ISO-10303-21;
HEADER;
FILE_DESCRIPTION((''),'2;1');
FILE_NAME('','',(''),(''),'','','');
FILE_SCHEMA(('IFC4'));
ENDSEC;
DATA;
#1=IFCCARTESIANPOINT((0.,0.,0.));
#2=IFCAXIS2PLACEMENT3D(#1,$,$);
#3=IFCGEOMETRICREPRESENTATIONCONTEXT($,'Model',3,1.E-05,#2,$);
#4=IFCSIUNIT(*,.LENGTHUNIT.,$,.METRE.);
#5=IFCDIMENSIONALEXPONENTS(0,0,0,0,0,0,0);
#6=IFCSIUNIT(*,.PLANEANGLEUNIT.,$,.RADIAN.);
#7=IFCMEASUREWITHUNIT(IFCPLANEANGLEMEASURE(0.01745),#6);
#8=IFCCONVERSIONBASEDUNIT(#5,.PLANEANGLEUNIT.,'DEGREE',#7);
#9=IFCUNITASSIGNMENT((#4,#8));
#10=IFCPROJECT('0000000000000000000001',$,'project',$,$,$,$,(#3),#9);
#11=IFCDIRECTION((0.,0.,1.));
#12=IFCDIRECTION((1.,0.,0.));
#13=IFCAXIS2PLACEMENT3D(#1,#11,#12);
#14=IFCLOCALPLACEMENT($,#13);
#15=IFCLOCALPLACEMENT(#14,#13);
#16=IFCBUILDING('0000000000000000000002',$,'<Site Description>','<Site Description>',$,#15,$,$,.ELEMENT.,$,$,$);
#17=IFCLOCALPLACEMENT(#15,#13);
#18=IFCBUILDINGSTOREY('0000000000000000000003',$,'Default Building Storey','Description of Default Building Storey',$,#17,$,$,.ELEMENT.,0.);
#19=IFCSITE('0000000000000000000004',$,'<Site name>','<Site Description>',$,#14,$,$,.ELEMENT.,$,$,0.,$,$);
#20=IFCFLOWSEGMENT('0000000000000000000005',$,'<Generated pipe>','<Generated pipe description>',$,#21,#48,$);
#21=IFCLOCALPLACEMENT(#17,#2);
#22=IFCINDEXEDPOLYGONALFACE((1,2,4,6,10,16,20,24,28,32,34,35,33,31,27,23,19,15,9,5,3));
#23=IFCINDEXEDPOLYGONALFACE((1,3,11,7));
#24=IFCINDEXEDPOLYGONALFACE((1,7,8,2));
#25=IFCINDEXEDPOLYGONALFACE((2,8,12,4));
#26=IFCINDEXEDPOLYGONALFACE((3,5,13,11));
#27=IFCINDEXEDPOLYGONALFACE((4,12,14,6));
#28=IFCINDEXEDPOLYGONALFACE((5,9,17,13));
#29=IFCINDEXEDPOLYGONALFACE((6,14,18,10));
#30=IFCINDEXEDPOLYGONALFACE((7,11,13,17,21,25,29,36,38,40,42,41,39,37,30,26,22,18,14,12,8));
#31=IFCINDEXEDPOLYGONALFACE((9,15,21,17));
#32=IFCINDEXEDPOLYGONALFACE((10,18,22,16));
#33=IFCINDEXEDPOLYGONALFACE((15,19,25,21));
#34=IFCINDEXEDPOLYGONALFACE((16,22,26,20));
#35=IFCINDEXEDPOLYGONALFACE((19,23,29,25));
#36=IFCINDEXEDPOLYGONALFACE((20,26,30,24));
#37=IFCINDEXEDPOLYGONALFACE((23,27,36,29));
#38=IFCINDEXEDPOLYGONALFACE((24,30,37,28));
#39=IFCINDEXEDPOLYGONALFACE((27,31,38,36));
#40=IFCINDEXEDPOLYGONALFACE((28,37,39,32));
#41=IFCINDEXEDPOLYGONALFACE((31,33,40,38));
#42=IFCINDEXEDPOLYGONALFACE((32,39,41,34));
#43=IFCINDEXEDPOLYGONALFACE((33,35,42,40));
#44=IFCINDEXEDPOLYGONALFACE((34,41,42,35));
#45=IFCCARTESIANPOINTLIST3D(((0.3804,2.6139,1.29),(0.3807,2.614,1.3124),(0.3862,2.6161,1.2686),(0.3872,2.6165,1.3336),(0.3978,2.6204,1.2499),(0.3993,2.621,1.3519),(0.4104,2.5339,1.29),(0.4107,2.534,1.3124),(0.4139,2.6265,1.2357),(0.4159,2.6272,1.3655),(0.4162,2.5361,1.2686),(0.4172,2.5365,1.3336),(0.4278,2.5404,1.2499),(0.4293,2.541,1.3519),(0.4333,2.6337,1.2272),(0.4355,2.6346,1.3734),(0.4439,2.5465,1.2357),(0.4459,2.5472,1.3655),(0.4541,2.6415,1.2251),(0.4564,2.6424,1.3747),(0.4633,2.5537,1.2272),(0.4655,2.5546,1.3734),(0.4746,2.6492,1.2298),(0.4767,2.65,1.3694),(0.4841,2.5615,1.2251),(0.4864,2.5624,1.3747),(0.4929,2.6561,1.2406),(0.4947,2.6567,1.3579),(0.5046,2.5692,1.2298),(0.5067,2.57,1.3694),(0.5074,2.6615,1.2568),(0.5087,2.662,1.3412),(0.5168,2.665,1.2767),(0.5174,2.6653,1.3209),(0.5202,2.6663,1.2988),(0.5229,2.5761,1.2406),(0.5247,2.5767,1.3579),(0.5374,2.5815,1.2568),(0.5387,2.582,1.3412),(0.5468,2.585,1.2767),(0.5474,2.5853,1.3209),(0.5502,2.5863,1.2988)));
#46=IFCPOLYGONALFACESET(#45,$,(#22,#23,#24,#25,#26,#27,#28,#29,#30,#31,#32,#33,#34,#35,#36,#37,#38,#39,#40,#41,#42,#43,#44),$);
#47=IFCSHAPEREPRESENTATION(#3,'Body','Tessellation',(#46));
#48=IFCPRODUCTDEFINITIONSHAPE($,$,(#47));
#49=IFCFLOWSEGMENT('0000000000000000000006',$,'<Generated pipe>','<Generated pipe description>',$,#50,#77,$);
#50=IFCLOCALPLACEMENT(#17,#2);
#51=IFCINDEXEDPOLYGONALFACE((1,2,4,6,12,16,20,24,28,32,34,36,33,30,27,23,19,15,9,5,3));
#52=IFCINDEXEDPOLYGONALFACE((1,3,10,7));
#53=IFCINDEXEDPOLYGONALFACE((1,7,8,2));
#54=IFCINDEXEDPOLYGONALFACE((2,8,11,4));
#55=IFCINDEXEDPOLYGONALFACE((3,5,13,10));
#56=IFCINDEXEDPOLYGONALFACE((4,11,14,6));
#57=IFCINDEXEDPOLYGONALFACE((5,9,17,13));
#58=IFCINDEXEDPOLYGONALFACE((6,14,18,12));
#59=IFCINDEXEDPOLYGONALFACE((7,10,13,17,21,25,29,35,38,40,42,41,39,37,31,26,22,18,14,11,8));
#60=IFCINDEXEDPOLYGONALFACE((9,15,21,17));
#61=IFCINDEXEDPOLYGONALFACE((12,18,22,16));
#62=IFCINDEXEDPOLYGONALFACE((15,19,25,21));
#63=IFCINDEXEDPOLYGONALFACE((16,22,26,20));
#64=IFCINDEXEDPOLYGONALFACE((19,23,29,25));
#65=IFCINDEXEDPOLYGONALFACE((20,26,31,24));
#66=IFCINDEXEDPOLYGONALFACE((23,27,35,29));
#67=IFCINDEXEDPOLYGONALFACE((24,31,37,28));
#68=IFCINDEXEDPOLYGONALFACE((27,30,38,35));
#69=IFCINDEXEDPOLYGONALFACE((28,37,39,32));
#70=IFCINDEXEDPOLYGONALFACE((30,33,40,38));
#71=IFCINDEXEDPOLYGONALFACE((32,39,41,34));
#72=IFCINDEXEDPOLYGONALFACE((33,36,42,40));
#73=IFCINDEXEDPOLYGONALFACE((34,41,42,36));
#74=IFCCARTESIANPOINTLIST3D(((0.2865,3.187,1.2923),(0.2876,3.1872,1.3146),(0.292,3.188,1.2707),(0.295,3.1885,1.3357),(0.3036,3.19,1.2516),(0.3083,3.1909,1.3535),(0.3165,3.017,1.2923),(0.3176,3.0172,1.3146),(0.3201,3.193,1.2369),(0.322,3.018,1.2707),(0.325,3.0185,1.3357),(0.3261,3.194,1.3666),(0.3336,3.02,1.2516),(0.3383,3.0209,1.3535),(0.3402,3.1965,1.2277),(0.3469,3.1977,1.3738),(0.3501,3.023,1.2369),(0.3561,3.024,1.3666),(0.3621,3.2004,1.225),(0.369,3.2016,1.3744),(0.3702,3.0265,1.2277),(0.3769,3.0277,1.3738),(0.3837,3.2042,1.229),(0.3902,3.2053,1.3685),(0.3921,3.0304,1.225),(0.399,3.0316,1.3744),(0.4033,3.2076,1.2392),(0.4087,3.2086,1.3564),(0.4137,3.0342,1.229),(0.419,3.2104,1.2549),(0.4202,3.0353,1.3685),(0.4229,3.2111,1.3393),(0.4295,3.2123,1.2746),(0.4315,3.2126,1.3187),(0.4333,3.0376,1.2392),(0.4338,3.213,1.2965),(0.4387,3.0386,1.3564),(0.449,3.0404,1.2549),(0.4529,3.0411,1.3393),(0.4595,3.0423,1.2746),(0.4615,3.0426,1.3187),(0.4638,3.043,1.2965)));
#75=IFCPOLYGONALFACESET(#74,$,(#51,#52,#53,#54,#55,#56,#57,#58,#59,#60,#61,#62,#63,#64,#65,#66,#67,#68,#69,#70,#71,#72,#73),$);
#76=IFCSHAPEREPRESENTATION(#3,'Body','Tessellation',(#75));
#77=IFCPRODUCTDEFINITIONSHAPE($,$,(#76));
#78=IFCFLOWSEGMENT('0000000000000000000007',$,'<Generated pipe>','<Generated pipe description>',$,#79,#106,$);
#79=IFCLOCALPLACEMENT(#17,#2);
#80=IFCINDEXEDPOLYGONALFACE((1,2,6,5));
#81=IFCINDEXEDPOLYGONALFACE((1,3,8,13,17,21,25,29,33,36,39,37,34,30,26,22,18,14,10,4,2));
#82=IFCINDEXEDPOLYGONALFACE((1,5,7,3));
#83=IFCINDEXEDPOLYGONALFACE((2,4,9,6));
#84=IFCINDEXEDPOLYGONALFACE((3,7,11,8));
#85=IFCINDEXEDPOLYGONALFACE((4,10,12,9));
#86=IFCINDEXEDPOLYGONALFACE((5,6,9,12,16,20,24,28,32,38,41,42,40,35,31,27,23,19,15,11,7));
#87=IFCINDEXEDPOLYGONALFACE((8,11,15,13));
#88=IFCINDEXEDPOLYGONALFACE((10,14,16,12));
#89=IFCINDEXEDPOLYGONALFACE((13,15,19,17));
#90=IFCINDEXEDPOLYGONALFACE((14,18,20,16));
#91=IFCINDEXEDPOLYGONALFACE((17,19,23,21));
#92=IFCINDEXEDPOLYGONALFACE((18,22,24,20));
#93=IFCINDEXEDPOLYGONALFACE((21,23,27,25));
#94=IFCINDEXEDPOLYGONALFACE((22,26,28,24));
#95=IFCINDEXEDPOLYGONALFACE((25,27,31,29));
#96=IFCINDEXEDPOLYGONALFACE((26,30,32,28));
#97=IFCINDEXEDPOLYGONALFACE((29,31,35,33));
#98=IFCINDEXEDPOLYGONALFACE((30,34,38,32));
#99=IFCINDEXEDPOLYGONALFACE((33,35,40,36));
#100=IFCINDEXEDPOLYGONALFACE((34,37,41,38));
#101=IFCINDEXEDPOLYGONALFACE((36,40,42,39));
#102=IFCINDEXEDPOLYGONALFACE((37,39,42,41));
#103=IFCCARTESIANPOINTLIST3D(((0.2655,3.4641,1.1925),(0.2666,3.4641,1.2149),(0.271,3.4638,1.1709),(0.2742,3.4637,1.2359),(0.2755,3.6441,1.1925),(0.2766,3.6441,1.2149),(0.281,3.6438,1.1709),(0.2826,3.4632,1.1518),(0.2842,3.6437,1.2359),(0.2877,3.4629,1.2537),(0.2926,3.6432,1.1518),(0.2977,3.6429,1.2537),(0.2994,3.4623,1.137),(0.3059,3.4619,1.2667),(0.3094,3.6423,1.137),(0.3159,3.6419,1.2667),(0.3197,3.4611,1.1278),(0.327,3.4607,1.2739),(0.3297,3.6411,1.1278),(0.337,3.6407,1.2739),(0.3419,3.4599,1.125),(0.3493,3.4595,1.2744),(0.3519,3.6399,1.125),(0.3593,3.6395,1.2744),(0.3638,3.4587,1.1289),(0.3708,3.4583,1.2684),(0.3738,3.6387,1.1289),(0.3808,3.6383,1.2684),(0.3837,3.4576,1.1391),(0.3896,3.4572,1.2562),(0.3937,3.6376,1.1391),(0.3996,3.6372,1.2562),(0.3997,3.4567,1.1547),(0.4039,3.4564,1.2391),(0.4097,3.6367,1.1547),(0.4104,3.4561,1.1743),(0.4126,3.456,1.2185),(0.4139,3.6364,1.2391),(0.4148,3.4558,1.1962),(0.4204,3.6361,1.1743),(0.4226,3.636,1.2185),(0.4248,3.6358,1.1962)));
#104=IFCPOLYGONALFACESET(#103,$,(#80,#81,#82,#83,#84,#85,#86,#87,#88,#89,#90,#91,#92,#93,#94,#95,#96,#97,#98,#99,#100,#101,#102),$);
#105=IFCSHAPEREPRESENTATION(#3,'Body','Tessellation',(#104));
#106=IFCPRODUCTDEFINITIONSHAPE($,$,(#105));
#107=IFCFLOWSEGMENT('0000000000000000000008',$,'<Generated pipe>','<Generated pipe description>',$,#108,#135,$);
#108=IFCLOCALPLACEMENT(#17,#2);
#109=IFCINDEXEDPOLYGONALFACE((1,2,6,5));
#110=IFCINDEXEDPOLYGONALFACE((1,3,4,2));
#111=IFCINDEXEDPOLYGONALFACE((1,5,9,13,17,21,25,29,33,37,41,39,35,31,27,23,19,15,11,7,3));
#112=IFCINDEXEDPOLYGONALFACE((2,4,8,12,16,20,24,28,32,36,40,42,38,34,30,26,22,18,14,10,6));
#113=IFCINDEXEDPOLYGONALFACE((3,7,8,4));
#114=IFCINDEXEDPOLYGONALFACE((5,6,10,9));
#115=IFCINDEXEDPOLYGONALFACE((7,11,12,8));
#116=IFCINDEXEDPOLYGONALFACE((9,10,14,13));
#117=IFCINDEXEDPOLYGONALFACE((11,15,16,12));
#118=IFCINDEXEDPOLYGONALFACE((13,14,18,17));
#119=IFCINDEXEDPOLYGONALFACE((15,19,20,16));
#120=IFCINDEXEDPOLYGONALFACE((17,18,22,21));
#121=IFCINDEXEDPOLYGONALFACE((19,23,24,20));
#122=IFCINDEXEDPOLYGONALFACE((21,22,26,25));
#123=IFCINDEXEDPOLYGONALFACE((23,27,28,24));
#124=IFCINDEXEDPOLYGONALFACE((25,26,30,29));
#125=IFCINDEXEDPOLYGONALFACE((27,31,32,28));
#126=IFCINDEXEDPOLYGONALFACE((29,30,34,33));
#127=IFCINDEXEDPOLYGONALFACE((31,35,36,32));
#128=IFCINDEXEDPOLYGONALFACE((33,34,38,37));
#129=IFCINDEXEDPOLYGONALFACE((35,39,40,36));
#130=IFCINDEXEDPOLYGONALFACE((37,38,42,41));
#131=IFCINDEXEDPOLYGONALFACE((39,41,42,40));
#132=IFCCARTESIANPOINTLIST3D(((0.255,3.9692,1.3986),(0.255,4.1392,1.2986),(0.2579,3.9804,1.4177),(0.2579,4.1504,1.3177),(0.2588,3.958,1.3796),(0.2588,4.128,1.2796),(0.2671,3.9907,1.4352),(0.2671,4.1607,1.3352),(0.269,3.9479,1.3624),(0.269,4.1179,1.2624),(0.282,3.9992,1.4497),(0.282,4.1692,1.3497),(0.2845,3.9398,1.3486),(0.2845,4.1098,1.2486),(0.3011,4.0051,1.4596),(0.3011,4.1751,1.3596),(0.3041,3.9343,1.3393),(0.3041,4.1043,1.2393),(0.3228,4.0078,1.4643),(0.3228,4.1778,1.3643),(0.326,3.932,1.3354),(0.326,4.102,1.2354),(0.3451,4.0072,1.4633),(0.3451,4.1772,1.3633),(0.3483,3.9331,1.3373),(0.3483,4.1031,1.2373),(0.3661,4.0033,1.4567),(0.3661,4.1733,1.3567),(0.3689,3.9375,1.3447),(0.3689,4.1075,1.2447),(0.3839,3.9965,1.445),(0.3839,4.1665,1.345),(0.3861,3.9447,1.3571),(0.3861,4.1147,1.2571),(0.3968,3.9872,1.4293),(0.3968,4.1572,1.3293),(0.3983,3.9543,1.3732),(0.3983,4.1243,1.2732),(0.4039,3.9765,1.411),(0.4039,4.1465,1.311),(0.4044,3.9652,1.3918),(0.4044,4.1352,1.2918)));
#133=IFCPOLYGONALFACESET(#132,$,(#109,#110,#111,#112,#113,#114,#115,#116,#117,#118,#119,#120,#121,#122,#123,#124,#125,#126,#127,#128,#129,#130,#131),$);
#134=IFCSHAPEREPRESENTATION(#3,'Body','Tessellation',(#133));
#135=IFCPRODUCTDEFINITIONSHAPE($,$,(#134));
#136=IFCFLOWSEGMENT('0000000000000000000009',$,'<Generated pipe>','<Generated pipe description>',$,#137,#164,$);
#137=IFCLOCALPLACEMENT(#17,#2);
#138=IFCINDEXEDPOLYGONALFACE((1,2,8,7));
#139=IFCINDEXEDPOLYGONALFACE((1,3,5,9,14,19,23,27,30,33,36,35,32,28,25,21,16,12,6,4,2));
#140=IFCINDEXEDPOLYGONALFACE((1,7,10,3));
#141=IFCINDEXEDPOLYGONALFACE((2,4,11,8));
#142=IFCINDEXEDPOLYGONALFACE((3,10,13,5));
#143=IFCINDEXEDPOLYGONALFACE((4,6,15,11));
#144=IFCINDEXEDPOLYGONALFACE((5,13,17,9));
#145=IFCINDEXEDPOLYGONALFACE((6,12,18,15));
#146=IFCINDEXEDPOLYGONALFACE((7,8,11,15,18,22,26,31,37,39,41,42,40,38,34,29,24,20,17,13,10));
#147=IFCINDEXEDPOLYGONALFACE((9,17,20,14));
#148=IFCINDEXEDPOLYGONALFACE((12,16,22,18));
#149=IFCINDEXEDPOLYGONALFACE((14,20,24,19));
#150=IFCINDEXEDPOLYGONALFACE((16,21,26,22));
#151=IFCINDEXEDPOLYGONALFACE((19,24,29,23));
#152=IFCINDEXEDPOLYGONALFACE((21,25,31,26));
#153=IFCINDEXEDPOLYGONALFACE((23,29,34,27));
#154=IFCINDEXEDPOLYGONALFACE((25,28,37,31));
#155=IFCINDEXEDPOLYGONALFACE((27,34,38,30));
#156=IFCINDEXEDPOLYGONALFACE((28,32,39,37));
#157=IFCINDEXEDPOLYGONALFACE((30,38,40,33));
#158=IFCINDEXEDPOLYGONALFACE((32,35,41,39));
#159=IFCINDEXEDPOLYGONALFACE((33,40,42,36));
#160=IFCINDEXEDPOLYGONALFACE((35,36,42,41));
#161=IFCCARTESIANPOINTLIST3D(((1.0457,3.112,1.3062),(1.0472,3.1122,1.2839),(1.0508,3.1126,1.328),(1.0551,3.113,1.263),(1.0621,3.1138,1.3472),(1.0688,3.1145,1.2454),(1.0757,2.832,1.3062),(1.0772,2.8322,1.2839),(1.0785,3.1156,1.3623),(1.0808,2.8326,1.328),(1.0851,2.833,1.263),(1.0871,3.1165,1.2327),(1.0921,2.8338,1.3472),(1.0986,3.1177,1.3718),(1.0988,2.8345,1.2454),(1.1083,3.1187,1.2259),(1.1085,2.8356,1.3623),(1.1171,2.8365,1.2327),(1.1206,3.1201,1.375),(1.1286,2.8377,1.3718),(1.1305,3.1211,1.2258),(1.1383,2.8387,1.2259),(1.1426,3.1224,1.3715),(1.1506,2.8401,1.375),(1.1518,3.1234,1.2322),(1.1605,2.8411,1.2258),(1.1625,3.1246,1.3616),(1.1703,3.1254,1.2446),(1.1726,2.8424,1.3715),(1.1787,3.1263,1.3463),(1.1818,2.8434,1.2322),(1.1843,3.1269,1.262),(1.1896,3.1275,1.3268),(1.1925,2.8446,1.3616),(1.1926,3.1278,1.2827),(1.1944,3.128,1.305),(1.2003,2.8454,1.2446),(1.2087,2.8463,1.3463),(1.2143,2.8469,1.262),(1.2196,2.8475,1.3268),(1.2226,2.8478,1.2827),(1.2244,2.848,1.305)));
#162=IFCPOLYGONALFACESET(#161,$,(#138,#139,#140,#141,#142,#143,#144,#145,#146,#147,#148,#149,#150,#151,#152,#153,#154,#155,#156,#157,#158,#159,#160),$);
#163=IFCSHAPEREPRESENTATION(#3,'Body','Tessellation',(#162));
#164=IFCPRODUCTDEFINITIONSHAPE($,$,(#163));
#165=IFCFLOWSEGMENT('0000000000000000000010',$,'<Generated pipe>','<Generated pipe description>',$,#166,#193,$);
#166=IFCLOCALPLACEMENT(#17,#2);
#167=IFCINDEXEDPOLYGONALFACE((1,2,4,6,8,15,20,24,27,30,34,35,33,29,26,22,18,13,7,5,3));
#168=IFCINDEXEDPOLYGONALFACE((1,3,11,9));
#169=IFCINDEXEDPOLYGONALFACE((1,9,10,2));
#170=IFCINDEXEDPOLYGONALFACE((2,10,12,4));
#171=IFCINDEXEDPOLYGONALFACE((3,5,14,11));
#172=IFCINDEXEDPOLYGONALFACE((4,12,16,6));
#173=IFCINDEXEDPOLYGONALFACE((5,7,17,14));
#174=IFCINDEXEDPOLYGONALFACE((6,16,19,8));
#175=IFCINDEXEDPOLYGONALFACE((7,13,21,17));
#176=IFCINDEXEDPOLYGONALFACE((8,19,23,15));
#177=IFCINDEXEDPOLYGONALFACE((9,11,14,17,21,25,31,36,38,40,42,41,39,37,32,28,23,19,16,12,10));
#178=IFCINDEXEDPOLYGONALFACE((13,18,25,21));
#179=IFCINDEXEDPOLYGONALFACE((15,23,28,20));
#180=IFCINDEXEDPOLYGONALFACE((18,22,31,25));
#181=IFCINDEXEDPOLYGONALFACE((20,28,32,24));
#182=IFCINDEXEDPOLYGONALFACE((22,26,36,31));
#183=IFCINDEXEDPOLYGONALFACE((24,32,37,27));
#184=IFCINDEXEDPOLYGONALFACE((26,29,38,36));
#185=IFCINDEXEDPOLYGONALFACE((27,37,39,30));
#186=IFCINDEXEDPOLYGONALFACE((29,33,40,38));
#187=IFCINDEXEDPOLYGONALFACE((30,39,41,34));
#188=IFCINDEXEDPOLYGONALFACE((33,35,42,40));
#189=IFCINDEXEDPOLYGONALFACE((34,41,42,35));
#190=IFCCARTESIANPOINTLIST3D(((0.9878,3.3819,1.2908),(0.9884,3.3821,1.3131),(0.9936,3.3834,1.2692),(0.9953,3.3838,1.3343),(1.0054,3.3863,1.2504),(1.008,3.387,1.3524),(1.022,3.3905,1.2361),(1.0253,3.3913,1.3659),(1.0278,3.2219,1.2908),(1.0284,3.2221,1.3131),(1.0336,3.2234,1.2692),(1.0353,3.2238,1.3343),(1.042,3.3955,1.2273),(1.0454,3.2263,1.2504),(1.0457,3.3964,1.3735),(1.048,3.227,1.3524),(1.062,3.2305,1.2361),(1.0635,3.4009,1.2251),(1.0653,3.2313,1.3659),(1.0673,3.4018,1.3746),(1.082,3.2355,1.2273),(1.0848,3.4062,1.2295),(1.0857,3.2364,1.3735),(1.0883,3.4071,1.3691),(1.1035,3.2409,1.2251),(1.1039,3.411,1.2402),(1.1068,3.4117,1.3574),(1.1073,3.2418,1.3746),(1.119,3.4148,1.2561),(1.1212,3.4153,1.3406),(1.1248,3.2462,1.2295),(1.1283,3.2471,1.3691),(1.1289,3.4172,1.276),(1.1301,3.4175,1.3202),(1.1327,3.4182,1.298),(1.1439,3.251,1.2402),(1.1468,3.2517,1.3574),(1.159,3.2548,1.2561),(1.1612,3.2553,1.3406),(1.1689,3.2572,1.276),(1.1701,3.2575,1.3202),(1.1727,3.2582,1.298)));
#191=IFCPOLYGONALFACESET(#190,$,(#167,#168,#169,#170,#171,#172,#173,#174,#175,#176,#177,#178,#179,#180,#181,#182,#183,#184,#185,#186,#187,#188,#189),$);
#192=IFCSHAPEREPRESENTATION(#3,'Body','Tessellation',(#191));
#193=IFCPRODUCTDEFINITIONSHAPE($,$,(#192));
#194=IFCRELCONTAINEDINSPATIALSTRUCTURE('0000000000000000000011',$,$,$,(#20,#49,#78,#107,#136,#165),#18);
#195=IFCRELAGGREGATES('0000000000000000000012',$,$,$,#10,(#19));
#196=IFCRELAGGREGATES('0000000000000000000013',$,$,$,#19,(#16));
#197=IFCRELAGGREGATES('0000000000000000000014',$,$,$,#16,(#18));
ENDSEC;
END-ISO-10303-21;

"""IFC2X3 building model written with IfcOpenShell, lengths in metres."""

from ifc_helpers import new_model, entity, si_unit, converted_unit, frame, origin, origin_with_axes, origin_2d_with_axis, place, context, project, spatial, circle, extrude, element, save


model = new_model("IFC2X3")

# Units and contexts
model_context = context("Model", 3, precision=1e-05, world=origin())
ifc_project = project(units=[si_unit("LENGTHUNIT", "METRE"), converted_unit("PLANEANGLEUNIT", "DEGREE", entity("IfcPlaneAngleMeasure", 0.01745), si_unit("PLANEANGLEUNIT", "RADIAN"), dimensions=[0, 0, 0, 0, 0, 0, 0])], contexts=[model_context])

# Site, building, storey
site_placement = place(None, origin_with_axes())
site = spatial("IfcSite", under=ifc_project, at=site_placement, Name="<Site name>", Description="<Site Description>", CompositionType="ELEMENT", RefElevation=0.0)
building_placement = place(site_placement, origin_with_axes())
building = spatial("IfcBuilding", under=site, at=building_placement, Name="<Site Description>", Description="<Site Description>", CompositionType="ELEMENT")
storey_placement = place(building_placement, origin_with_axes())
storey = spatial("IfcBuildingStorey", under=building, at=storey_placement, Name="Default Building Storey", Description="Description of Default Building Storey", CompositionType="ELEMENT", Elevation=0.0)

# Flow segments
flow_segment_1_placement = place(storey_placement, frame((0.48, 2.56, 1.3), z_axis=(-0.351123, 0.936329, 0.0), x_axis=(0.356102, 0.133538, 0.924856)))
element("IfcFlowSegment", 1, at=flow_segment_1_placement, inside=storey, Name="<Generated pipe>", Description="<Generated pipe description>", context=model_context, shape_type="SweptSolid", body=[
    extrude(circle(Radius=0.075, at=origin_2d_with_axis()), origin_with_axes(), (0.0, 0.0, 1.0), 0.0854),
])
flow_segment_2_placement = place(storey_placement, frame((0.39, 3.03, 1.3), z_axis=(-0.173785, 0.984784, 0.0), x_axis=(0.402235, 0.070983, 0.91278)))
element("IfcFlowSegment", 2, at=flow_segment_2_placement, inside=storey, Name="<Generated pipe>", Description="<Generated pipe description>", context=model_context, shape_type="SweptSolid", body=[
    extrude(circle(Radius=0.075, at=origin_2d_with_axis()), origin_with_axes(), (0.0, 0.0, 1.0), 0.1726),
])
flow_segment_3_placement = place(storey_placement, frame((0.34, 3.46, 1.2), z_axis=(0.05547, 0.99846, 0.0), x_axis=(0.967637, -0.053758, 0.246554)))
element("IfcFlowSegment", 3, at=flow_segment_3_placement, inside=storey, Name="<Generated pipe>", Description="<Generated pipe description>", context=model_context, shape_type="SweptSolid", body=[
    extrude(circle(Radius=0.075, at=origin_2d_with_axis()), origin_with_axes(), (0.0, 0.0, 1.0), 0.1803),
])
flow_segment_4_placement = place(storey_placement, frame((0.33, 3.97, 1.4), z_axis=(0.0, 0.861934, -0.50702), x_axis=(0.481042, 0.444503, 0.755656)))
element("IfcFlowSegment", 4, at=flow_segment_4_placement, inside=storey, Name="<Generated pipe>", Description="<Generated pipe description>", context=model_context, shape_type="SweptSolid", body=[
    extrude(circle(Radius=0.075, at=origin_2d_with_axis()), origin_with_axes(), (0.0, 0.0, 1.0), 0.1972),
])
flow_segment_5_placement = place(storey_placement, frame((1.15, 2.84, 1.3), z_axis=(-0.106533, 0.994309, 0.0), x_axis=(0.300703, 0.032218, 0.953174)))
element("IfcFlowSegment", 5, at=flow_segment_5_placement, inside=storey, Name="<Generated pipe>", Description="<Generated pipe description>", context=model_context, shape_type="SweptSolid", body=[
    extrude(circle(Radius=0.075, at=origin_2d_with_axis()), origin_with_axes(), (0.0, 0.0, 1.0), 0.2816),
])
flow_segment_6_placement = place(storey_placement, frame((1.1, 3.24, 1.3), z_axis=(-0.242536, 0.970143, 0.0), x_axis=(0.377949, 0.094487, 0.920992)))
element("IfcFlowSegment", 6, at=flow_segment_6_placement, inside=storey, Name="<Generated pipe>", Description="<Generated pipe description>", context=model_context, shape_type="SweptSolid", body=[
    extrude(circle(Radius=0.075, at=origin_2d_with_axis()), origin_with_axes(), (0.0, 0.0, 1.0), 0.1649),
])

save(model, "model.ifc")
